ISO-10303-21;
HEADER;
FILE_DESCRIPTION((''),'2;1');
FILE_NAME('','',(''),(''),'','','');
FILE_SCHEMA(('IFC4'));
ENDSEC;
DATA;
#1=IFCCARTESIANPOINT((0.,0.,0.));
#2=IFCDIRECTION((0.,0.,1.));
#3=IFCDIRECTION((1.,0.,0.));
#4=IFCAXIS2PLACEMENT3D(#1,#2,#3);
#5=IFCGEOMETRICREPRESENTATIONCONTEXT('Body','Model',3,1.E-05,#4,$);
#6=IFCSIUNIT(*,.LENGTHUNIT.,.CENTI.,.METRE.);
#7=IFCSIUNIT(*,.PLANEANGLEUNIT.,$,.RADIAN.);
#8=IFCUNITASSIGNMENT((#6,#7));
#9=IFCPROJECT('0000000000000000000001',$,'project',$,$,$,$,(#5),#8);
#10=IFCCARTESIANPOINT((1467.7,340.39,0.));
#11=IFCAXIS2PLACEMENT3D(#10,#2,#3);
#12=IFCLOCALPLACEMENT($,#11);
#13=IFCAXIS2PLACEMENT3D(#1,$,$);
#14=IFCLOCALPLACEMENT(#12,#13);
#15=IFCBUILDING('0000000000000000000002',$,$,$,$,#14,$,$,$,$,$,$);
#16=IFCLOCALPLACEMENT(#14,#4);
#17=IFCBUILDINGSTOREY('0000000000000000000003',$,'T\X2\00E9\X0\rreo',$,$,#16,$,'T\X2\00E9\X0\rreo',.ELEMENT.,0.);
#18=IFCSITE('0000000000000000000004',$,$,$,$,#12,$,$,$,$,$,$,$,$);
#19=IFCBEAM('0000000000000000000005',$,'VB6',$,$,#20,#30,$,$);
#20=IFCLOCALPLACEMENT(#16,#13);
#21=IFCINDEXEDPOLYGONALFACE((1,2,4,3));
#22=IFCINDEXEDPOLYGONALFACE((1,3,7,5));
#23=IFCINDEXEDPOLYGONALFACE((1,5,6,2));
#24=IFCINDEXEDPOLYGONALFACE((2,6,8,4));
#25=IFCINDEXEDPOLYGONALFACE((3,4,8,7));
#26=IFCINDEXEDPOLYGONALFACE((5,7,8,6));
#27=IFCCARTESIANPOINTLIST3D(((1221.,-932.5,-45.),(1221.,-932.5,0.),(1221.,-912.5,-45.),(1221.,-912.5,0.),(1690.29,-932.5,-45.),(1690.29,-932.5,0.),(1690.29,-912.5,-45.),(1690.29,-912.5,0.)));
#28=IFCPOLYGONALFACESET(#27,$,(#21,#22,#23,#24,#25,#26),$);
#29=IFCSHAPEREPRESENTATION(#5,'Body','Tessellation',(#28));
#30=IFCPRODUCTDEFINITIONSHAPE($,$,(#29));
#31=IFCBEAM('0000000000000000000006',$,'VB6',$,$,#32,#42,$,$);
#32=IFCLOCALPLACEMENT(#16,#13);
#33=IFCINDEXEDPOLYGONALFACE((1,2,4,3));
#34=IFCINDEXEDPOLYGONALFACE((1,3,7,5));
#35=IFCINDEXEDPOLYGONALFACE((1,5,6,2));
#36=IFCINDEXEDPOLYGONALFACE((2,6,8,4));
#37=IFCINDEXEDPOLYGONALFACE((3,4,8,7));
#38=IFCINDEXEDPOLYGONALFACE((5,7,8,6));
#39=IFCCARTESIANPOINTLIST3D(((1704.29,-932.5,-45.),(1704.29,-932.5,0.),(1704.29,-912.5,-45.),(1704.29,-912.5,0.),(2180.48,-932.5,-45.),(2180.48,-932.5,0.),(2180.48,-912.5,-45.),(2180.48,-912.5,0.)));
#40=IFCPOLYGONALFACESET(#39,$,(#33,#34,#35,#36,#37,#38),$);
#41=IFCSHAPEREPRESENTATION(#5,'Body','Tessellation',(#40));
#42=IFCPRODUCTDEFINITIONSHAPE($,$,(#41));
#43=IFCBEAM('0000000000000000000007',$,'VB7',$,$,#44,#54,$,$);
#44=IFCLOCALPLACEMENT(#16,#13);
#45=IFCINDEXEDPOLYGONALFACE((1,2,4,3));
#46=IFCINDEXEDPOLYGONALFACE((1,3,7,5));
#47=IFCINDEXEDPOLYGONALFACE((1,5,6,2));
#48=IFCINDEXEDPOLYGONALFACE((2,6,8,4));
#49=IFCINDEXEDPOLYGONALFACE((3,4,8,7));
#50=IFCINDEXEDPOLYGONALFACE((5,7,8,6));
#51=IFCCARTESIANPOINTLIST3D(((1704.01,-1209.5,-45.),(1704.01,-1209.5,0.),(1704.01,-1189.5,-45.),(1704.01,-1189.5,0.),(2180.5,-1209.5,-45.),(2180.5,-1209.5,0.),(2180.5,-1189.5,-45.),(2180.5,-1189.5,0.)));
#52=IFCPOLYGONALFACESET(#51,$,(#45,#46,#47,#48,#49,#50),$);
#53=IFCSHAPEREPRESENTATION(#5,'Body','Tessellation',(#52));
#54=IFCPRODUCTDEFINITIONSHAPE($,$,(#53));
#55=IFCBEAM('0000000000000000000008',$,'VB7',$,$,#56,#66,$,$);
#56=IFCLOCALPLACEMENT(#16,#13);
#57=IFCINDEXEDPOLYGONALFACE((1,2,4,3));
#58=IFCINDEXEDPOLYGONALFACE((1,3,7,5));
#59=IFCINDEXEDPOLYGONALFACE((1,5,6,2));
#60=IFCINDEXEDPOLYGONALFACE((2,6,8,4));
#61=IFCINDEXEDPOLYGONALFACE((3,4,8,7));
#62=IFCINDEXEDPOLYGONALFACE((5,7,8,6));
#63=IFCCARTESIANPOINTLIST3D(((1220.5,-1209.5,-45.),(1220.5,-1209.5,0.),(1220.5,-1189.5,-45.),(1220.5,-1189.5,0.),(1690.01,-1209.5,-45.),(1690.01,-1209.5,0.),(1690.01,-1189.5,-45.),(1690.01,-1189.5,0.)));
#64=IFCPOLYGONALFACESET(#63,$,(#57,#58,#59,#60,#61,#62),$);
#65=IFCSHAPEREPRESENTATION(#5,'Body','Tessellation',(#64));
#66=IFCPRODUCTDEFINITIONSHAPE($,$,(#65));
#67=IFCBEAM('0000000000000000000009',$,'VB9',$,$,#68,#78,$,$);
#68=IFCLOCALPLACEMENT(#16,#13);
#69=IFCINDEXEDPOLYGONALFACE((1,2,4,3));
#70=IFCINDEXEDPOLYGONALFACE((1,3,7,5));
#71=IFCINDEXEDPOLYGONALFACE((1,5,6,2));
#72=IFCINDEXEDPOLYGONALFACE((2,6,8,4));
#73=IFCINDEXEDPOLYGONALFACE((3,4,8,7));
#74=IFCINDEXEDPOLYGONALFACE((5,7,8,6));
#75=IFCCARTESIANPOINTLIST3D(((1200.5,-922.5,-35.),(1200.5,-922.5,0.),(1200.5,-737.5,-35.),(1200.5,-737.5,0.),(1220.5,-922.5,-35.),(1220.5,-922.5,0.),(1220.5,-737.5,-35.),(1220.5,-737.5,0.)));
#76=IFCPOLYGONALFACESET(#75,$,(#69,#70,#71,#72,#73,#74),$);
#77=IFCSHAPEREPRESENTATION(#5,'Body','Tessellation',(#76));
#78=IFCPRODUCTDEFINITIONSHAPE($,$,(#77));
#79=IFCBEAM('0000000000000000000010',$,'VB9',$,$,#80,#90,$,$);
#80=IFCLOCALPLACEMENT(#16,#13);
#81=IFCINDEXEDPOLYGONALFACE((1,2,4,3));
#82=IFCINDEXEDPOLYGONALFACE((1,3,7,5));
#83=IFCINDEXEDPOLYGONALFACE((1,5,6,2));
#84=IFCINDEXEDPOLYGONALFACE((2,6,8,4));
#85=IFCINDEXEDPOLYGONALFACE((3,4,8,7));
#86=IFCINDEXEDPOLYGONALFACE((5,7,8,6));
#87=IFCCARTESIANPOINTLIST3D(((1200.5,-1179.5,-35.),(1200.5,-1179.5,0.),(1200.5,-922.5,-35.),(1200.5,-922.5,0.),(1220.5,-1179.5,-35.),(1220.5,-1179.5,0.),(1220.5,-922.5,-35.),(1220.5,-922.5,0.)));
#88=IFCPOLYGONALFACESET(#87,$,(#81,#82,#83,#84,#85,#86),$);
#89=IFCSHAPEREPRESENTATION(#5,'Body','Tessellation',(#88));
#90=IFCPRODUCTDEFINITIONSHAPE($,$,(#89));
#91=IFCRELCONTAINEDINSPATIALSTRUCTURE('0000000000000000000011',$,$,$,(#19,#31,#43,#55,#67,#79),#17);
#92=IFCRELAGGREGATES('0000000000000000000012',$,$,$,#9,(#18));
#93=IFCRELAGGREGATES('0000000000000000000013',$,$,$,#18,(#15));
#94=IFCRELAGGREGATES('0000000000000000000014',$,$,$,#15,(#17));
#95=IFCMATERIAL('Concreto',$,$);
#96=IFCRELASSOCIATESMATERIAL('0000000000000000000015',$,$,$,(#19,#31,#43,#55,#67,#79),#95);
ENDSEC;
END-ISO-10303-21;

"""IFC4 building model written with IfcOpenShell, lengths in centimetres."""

from ifc_helpers import new_model, si_unit, frame, origin, origin_with_axes, origin_2d_with_axis, place, context, project, spatial, rectangle, extrude, material, element, save


model = new_model("IFC4")

# Units and contexts
model_context = context("Model", 3, precision=1e-05, world=origin_with_axes(), identifier="Body")
ifc_project = project(units=[si_unit("LENGTHUNIT", "METRE", prefix="CENTI"), si_unit("PLANEANGLEUNIT", "RADIAN")], contexts=[model_context])

# Site, building, storey
site_placement = place(None, frame((1467.7, 340.39, 0.0), z_axis=(0.0, 0.0, 1.0), x_axis=(1.0, 0.0, 0.0)))
site = spatial("IfcSite", under=ifc_project, at=site_placement)
building_placement = place(site_placement, origin())
building = spatial("IfcBuilding", under=site, at=building_placement)
storey_placement = place(building_placement, origin_with_axes())
storey = spatial("IfcBuildingStorey", under=building, at=storey_placement, Name="Térreo", LongName="Térreo", CompositionType="ELEMENT", Elevation=0.0)

# Shared definitions
ifc_material = material(Name="Concreto")

# Beams
beam_1_placement = place(storey_placement, frame((1455.64, -922.5, 0.0), z_axis=(0.0, 0.0, 1.0), x_axis=(1.0, 0.0, 0.0)))
element("IfcBeam", 1, at=beam_1_placement, inside=storey, material=ifc_material, Name="VB6", context=model_context, shape_type="SolidModel", body=[
    extrude(rectangle(XDim=20.0, YDim=45.0, at=origin_2d_with_axis()), frame((-234.65, 0.0, -22.5), z_axis=(1.0, 0.0, 0.0), x_axis=(0.0, -1.0, 0.0)), (0.0, 0.0, 1.0), 469.29),
])
beam_2_placement = place(storey_placement, frame((1942.38, -922.5, 0.0), z_axis=(0.0, 0.0, 1.0), x_axis=(1.0, 0.0, 0.0)))
element("IfcBeam", 2, at=beam_2_placement, inside=storey, material=ifc_material, Name="VB6", context=model_context, shape_type="SolidModel", body=[
    extrude(rectangle(XDim=20.0, YDim=45.0, at=origin_2d_with_axis()), frame((-238.09, 0.0, -22.5), z_axis=(1.0, 0.0, 0.0), x_axis=(0.0, 1.0, 0.0)), (0.0, 0.0, 1.0), 476.19),
])
beam_3_placement = place(storey_placement, frame((1942.26, -1199.5, 0.0), z_axis=(0.0, 0.0, 1.0), x_axis=(1.0, 0.0, 0.0)))
element("IfcBeam", 3, at=beam_3_placement, inside=storey, material=ifc_material, Name="VB7", context=model_context, shape_type="SolidModel", body=[
    extrude(rectangle(XDim=20.0, YDim=45.0, at=origin_2d_with_axis()), frame((-238.25, 0.0, -22.5), z_axis=(1.0, 0.0, 0.0), x_axis=(0.0, -1.0, 0.0)), (0.0, 0.0, 1.0), 476.49),
])
beam_4_placement = place(storey_placement, frame((1455.26, -1199.5, 0.0), z_axis=(0.0, 0.0, 1.0), x_axis=(1.0, 0.0, 0.0)))
element("IfcBeam", 4, at=beam_4_placement, inside=storey, material=ifc_material, Name="VB7", context=model_context, shape_type="SolidModel", body=[
    extrude(rectangle(XDim=20.0, YDim=45.0, at=origin_2d_with_axis()), frame((-234.75, 0.0, -22.5), z_axis=(1.0, 0.0, 0.0), x_axis=(0.0, -1.0, 0.0)), (0.0, 0.0, 1.0), 469.51),
])
beam_5_placement = place(storey_placement, frame((1210.5, -830.0, 0.0), z_axis=(0.0, 0.0, 1.0), x_axis=(1.0, 0.0, 0.0)))
element("IfcBeam", 5, at=beam_5_placement, inside=storey, material=ifc_material, Name="VB9", context=model_context, shape_type="SolidModel", body=[
    extrude(rectangle(XDim=20.0, YDim=35.0, at=origin_2d_with_axis()), frame((0.0, -92.5, -17.5), z_axis=(0.0, 1.0, 0.0), x_axis=(1.0, 0.0, 0.0)), (0.0, 0.0, 1.0), 185.0),
])
beam_6_placement = place(storey_placement, frame((1210.5, -1051.0, 0.0), z_axis=(0.0, 0.0, 1.0), x_axis=(1.0, 0.0, 0.0)))
element("IfcBeam", 6, at=beam_6_placement, inside=storey, material=ifc_material, Name="VB9", context=model_context, shape_type="SolidModel", body=[
    extrude(rectangle(XDim=20.0, YDim=35.0, at=origin_2d_with_axis()), frame((0.0, -128.5, -17.5), z_axis=(0.0, 1.0, 0.0), x_axis=(1.0, 0.0, 0.0)), (0.0, 0.0, 1.0), 257.0),
])

save(model, "model.ifc")
